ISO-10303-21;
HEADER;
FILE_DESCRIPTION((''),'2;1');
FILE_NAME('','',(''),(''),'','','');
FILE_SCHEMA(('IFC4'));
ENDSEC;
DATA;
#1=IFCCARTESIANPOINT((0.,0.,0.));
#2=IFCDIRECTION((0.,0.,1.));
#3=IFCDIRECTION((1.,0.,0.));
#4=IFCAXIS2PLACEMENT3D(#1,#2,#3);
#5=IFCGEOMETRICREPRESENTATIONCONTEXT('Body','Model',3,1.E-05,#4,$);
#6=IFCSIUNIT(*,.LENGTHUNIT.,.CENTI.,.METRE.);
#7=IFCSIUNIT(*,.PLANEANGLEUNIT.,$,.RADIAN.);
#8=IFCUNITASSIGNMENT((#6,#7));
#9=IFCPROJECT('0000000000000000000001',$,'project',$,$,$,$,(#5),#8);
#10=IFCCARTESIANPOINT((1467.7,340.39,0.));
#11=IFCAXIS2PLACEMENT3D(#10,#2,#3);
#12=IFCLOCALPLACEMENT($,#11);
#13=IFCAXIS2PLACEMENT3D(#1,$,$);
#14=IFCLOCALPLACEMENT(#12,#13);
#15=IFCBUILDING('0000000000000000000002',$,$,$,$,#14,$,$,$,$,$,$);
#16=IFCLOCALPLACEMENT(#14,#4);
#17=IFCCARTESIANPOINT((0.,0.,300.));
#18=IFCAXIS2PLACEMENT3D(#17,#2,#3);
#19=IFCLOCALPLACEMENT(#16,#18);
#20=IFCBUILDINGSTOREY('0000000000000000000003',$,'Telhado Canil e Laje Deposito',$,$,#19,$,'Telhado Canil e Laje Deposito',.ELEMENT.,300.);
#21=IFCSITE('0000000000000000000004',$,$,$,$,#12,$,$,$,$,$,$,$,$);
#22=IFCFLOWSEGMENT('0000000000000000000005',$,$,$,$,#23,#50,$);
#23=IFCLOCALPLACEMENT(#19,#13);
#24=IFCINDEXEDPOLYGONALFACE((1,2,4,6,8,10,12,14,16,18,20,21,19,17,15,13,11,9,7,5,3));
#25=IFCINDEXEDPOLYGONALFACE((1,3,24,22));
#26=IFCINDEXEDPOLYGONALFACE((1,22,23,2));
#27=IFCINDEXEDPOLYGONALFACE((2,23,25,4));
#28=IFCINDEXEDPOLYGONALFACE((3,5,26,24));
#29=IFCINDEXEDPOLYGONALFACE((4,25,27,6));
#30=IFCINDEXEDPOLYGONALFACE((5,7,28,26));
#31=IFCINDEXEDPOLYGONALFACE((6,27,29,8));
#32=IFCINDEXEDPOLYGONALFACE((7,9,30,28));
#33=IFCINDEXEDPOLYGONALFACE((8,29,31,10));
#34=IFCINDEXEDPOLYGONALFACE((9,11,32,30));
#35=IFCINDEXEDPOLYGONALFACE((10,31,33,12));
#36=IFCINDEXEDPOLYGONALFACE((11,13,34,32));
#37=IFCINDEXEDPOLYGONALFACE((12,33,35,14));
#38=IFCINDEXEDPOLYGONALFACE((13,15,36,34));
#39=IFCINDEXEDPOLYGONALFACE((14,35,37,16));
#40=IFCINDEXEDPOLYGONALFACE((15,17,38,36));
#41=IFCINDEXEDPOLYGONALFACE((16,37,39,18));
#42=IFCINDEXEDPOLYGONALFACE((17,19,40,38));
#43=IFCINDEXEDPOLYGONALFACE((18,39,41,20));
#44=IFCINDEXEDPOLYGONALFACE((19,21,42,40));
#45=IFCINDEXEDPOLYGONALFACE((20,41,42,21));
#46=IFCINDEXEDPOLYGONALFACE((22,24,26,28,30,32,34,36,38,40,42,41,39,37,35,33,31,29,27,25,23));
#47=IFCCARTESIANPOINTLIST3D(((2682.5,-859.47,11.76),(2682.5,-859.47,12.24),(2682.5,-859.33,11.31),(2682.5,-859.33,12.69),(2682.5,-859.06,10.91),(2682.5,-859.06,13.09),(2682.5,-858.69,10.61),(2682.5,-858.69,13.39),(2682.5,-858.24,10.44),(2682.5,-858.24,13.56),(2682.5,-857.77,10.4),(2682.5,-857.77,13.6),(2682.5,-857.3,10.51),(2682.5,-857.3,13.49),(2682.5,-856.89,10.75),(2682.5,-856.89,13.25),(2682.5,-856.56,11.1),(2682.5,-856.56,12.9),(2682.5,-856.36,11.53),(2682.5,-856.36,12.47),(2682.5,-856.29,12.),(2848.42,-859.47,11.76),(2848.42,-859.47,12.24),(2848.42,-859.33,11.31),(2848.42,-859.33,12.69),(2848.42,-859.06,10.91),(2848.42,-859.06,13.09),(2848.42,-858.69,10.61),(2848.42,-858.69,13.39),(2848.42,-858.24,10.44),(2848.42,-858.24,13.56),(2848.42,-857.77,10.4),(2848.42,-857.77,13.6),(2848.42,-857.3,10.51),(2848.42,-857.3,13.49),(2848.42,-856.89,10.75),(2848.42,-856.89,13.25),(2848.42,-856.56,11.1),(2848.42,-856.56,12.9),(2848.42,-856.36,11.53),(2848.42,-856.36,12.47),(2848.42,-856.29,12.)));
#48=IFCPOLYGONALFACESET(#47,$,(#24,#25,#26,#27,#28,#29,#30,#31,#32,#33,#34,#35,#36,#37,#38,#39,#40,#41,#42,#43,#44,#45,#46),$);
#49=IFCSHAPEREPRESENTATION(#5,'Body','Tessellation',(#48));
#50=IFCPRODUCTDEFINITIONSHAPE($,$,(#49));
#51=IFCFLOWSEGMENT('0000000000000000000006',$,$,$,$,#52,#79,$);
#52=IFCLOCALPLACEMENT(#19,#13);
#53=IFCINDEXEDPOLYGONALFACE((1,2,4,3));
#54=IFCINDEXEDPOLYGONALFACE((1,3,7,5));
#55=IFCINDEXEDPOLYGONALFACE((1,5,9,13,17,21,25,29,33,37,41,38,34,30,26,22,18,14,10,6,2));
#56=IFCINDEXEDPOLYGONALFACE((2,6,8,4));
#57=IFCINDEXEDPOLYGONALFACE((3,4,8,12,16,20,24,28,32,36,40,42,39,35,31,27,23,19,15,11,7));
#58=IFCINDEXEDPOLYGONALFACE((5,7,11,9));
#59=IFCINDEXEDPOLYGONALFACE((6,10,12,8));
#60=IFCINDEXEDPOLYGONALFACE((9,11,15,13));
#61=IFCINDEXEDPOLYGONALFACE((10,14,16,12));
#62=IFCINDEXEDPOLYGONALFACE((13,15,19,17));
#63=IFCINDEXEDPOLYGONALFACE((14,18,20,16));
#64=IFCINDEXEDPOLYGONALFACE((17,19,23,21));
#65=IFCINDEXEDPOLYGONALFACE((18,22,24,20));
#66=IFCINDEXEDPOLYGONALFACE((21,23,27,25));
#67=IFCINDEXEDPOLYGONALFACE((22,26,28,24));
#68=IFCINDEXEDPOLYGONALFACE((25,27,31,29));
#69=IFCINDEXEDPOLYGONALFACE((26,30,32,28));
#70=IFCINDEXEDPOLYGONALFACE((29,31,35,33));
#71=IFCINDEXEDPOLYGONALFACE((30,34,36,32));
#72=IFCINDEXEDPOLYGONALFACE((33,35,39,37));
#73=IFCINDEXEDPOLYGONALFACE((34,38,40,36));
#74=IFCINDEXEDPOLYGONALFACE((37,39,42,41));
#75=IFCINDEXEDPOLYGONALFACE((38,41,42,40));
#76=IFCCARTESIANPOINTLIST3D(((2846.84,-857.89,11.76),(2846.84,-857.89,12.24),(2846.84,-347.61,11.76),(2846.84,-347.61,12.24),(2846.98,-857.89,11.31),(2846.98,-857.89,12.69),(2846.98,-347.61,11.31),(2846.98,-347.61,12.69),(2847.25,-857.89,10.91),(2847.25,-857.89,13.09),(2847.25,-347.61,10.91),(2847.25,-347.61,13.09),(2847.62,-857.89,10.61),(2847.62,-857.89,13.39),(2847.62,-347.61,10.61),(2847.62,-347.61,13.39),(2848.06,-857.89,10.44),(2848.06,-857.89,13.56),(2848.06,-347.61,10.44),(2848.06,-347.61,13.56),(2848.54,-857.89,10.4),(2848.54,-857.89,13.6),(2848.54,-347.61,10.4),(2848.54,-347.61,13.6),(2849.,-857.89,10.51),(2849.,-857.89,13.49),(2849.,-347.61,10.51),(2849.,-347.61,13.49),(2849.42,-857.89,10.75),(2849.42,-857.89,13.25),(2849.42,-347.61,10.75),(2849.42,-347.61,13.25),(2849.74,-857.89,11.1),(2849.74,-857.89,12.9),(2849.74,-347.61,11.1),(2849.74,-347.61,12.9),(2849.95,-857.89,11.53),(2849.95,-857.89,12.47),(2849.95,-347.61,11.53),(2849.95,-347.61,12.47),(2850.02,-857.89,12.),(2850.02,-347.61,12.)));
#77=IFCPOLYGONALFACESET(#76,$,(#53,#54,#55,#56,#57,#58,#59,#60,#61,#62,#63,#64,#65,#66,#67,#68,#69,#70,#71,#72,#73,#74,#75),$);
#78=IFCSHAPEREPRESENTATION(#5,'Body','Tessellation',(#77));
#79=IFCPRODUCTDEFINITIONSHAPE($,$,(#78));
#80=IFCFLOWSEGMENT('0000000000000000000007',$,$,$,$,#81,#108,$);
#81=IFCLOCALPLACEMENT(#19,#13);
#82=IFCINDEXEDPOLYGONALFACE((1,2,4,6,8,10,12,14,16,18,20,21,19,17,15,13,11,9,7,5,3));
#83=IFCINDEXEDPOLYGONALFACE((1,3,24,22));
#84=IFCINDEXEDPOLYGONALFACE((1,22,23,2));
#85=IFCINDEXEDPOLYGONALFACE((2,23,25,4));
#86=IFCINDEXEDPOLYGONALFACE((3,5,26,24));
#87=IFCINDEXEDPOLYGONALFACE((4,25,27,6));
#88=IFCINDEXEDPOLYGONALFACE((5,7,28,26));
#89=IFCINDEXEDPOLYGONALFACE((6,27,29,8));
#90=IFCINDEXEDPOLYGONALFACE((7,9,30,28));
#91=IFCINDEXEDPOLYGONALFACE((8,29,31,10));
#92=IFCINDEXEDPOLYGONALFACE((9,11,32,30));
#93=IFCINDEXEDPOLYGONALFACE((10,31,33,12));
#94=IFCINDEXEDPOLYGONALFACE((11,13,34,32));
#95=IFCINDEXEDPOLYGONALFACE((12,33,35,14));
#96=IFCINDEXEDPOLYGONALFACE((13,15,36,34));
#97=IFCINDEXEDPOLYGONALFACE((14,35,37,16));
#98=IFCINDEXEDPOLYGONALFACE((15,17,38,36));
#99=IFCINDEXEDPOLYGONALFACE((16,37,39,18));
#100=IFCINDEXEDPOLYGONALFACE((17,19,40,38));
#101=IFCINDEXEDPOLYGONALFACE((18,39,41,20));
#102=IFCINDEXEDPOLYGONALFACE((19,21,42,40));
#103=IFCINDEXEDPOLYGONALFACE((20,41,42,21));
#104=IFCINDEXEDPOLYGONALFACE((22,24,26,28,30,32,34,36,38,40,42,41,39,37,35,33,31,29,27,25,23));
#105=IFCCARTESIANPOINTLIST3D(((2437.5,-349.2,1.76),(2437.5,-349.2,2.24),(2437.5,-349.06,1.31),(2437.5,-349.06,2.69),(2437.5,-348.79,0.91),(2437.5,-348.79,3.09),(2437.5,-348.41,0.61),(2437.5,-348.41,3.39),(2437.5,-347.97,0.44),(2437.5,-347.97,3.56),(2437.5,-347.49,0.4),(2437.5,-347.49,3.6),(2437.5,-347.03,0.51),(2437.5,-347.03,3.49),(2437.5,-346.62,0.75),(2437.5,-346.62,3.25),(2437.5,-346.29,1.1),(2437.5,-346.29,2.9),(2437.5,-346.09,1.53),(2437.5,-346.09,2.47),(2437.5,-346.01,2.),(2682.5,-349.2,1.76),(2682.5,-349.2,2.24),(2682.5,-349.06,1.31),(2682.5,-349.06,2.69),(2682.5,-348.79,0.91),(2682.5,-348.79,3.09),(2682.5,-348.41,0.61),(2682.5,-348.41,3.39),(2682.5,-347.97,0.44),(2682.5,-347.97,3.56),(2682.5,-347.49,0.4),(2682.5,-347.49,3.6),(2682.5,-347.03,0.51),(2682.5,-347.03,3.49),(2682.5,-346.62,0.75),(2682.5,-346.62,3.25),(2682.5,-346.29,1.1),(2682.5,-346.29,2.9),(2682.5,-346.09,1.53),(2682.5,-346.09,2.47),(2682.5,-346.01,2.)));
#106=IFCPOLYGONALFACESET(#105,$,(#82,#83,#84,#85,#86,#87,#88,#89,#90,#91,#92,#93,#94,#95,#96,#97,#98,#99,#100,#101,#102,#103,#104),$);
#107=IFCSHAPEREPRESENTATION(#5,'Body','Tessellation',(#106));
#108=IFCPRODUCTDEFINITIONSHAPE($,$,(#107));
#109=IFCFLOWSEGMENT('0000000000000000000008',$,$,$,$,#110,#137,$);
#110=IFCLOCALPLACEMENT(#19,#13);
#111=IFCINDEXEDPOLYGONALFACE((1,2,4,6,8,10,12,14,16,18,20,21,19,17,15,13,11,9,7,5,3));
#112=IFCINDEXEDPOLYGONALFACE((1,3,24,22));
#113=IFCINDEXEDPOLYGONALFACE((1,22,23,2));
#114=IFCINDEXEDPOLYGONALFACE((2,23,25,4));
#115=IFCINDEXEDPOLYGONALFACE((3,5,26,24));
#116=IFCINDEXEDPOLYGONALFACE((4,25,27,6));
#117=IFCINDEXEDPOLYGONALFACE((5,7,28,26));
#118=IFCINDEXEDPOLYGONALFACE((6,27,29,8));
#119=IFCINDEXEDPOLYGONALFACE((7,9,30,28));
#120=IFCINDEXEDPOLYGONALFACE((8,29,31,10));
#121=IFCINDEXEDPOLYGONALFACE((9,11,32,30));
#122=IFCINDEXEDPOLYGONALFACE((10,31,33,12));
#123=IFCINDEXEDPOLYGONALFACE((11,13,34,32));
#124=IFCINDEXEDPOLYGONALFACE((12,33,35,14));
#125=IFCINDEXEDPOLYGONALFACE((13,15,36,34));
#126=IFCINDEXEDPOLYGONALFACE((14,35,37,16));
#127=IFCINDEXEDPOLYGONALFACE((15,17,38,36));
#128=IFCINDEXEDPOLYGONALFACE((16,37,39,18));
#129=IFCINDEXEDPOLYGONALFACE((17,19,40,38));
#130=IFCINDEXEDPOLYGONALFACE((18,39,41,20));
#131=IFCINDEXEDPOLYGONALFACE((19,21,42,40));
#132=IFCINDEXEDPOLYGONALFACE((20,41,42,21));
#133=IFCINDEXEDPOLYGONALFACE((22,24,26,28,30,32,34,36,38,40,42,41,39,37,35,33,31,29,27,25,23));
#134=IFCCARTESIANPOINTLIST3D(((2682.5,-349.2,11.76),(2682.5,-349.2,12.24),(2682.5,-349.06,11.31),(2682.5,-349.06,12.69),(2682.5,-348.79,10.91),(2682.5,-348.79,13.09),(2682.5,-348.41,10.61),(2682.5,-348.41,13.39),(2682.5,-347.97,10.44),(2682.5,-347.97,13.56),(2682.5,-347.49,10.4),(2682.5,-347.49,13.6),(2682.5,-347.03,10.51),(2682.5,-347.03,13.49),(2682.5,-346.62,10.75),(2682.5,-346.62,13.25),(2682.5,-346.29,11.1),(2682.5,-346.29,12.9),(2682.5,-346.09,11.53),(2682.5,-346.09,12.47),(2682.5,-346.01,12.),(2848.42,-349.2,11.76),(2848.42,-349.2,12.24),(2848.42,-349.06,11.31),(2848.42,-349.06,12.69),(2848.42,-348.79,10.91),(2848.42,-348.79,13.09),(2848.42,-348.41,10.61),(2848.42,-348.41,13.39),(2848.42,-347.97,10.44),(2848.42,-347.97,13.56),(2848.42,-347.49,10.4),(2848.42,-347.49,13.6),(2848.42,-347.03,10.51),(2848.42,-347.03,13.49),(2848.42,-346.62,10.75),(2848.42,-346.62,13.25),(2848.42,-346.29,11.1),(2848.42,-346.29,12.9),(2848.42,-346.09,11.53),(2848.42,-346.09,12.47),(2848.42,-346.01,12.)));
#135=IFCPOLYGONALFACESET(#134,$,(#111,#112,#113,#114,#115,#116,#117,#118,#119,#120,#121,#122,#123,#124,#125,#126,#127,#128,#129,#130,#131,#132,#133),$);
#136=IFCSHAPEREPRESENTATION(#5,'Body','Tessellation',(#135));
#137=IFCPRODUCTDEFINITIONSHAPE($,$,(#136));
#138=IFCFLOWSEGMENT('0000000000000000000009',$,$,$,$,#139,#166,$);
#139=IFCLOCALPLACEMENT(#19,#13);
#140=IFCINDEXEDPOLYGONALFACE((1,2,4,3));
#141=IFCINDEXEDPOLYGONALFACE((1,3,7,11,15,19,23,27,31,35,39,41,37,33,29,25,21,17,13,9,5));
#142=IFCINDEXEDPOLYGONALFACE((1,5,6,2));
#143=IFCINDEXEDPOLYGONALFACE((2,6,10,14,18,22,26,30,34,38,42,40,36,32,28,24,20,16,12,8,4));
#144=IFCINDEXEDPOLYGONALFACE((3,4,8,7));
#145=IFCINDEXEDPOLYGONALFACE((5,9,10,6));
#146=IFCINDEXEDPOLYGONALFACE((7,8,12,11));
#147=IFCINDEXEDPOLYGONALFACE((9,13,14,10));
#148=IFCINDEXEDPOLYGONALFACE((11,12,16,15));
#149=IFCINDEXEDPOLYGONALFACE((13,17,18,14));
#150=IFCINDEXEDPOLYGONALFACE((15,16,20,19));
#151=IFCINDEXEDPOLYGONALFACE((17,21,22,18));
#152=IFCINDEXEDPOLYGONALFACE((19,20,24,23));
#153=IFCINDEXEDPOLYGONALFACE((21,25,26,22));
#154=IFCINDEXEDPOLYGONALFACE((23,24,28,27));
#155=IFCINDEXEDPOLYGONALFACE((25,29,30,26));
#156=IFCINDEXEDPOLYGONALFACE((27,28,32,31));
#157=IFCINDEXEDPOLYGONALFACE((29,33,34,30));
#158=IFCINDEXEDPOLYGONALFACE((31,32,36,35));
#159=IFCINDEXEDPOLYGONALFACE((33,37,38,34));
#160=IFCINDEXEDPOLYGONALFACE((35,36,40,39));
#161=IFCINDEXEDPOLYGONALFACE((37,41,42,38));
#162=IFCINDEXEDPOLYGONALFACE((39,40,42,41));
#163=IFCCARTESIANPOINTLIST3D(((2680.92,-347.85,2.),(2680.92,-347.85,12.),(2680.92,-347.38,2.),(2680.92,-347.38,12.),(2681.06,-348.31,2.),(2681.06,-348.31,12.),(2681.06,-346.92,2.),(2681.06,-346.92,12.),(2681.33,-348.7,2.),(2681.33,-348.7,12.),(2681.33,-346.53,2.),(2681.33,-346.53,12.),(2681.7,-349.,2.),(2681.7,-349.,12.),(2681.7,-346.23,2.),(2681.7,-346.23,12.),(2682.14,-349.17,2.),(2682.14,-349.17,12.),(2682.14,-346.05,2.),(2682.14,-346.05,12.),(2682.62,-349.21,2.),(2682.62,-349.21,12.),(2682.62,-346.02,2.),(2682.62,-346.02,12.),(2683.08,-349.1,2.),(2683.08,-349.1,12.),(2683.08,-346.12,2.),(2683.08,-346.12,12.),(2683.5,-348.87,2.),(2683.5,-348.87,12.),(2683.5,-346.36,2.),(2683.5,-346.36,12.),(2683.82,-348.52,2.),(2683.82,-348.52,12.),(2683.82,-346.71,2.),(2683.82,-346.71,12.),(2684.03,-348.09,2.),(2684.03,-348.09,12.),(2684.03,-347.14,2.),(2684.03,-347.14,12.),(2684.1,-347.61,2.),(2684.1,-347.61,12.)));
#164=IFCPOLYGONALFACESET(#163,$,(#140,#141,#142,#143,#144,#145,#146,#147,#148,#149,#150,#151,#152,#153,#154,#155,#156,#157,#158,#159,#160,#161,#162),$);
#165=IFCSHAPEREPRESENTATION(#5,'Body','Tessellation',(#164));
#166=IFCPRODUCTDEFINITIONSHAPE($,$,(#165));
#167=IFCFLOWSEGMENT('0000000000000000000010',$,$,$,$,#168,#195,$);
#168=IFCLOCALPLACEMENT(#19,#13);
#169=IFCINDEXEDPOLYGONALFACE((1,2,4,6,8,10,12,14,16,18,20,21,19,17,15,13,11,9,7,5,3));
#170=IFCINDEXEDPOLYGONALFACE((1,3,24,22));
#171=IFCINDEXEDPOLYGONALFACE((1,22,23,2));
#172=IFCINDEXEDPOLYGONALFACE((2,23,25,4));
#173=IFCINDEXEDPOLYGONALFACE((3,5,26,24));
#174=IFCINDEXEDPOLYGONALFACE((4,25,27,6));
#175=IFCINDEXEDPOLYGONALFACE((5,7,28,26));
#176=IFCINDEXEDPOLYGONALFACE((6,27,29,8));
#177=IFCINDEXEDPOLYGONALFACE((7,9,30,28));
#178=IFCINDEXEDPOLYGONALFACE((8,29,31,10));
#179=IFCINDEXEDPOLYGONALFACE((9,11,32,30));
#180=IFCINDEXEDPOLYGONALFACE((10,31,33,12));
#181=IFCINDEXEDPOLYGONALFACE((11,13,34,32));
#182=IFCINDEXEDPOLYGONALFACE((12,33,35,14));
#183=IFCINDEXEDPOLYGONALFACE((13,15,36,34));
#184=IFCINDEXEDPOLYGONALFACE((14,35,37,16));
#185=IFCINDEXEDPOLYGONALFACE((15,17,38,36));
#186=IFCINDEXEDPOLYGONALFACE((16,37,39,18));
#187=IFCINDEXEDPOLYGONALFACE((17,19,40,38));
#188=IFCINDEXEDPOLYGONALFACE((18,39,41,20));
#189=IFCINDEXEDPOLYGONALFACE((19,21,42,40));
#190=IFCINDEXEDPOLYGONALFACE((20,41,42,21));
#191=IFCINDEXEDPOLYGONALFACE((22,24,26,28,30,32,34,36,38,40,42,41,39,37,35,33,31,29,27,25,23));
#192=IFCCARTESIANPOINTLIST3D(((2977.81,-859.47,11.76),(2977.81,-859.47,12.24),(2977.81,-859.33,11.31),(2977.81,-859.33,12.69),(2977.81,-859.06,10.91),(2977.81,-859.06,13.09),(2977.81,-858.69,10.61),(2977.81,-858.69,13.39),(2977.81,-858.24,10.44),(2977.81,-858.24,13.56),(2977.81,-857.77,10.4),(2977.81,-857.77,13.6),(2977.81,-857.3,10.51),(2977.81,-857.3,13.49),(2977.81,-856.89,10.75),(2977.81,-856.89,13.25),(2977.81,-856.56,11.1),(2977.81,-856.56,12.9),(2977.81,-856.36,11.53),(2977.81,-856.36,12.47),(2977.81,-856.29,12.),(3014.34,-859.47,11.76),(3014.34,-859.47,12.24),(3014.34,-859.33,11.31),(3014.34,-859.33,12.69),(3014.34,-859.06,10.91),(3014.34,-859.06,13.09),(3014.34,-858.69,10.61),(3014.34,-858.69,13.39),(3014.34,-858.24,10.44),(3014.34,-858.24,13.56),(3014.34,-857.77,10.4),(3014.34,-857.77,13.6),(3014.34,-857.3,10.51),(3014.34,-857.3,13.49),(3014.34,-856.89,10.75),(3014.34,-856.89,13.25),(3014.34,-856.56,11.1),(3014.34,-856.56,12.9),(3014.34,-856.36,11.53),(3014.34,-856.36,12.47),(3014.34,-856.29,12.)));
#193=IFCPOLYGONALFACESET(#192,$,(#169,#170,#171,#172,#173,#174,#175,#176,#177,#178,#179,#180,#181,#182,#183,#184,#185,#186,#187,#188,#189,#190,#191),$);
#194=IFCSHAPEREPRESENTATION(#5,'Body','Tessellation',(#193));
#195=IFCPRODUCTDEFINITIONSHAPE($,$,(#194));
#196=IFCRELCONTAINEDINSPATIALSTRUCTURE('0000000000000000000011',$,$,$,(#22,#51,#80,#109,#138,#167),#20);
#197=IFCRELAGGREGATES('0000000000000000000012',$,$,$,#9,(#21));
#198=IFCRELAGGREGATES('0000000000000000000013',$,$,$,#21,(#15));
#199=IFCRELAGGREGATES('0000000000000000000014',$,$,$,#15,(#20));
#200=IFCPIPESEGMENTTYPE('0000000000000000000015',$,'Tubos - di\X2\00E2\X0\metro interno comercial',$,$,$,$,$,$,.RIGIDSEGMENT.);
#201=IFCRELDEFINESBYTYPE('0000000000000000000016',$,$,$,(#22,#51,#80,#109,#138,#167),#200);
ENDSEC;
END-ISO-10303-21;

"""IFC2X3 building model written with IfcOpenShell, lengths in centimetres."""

from ifc_helpers import new_model, si_unit, frame, origin, origin_with_axes, origin_2d_with_axis, place, context, project, spatial, circle, extrude, type_object, element, save


model = new_model("IFC2X3")

# Units and contexts
model_context = context("Model", 3, precision=1e-05, world=origin_with_axes(), identifier="Body")
ifc_project = project(units=[si_unit("LENGTHUNIT", "METRE", prefix="CENTI"), si_unit("PLANEANGLEUNIT", "RADIAN")], contexts=[model_context])

# Site, building, storey
site_placement = place(None, frame((1467.7, 340.39, 0.0), z_axis=(0.0, 0.0, 1.0), x_axis=(1.0, 0.0, 0.0)))
site = spatial("IfcSite", under=ifc_project, at=site_placement)
building_placement = place(site_placement, origin())
building = spatial("IfcBuilding", under=site, at=building_placement)
placement = place(building_placement, origin_with_axes())
storey_placement = place(placement, frame((0.0, 0.0, 300.0), z_axis=(0.0, 0.0, 1.0), x_axis=(1.0, 0.0, 0.0)))
storey = spatial("IfcBuildingStorey", under=building, at=storey_placement, Name="Telhado Canil e Laje Deposito", LongName="Telhado Canil e Laje Deposito", CompositionType="ELEMENT", Elevation=300.0)

# Flow segments
pipe_segment_type = type_object("IfcPipeSegmentType", Name="Tubos - diâmetro interno comercial", PredefinedType="RIGIDSEGMENT")
flow_segment_1_placement = place(storey_placement, frame((2765.46, -857.89, 13.6), z_axis=(0.0, 0.0, 1.0), x_axis=(1.0, 0.0, 0.0)))
element("IfcFlowSegment", 1, at=flow_segment_1_placement, inside=storey, type_object=pipe_segment_type, context=model_context, shape_type="SolidModel", body=[
    extrude(circle(Radius=1.6, at=origin_2d_with_axis()), frame((82.96, 0.0, -1.6), z_axis=(-1.0, 0.0, 0.0), x_axis=(0.0, 1.0, 0.0)), (0.0, 0.0, 1.0), 165.92),
])
flow_segment_2_placement = place(storey_placement, frame((2848.42, -602.75, 13.6), z_axis=(0.0, 0.0, 1.0), x_axis=(1.0, 0.0, 0.0)))
element("IfcFlowSegment", 2, at=flow_segment_2_placement, inside=storey, type_object=pipe_segment_type, context=model_context, shape_type="SolidModel", body=[
    extrude(circle(Radius=1.6, at=origin_2d_with_axis()), frame((0.0, -255.14, -1.6), z_axis=(0.0, 1.0, 0.0), x_axis=(1.0, 0.0, 0.0)), (0.0, 0.0, 1.0), 510.27),
])
flow_segment_3_placement = place(storey_placement, frame((2560.0, -347.61, 3.6), z_axis=(0.0, 0.0, 1.0), x_axis=(1.0, 0.0, 0.0)))
element("IfcFlowSegment", 3, at=flow_segment_3_placement, inside=storey, type_object=pipe_segment_type, context=model_context, shape_type="SolidModel", body=[
    extrude(circle(Radius=1.6, at=origin_2d_with_axis()), frame((122.5, 0.0, -1.6), z_axis=(-1.0, 0.0, 0.0), x_axis=(0.0, 1.0, 0.0)), (0.0, 0.0, 1.0), 245.0),
])
flow_segment_4_placement = place(storey_placement, frame((2765.46, -347.61, 13.6), z_axis=(0.0, 0.0, 1.0), x_axis=(1.0, 0.0, 0.0)))
element("IfcFlowSegment", 4, at=flow_segment_4_placement, inside=storey, type_object=pipe_segment_type, context=model_context, shape_type="SolidModel", body=[
    extrude(circle(Radius=1.6, at=origin_2d_with_axis()), frame((82.96, 0.0, -1.6), z_axis=(-1.0, 0.0, 0.0), x_axis=(0.0, 1.0, 0.0)), (0.0, 0.0, 1.0), 165.92),
])
flow_segment_5_placement = place(storey_placement, frame((2682.5, -347.61, 12.0), z_axis=(0.0, 0.0, 1.0), x_axis=(1.0, 0.0, 0.0)))
element("IfcFlowSegment", 5, at=flow_segment_5_placement, inside=storey, type_object=pipe_segment_type, context=model_context, shape_type="SolidModel", body=[
    extrude(circle(Radius=1.6, at=origin_2d_with_axis()), frame((0.0, 0.0, 0.0), z_axis=(0.0, 0.0, -1.0), x_axis=(1.0, 0.0, 0.0)), (0.0, 0.0, 1.0), 10.0),
])
flow_segment_6_placement = place(storey_placement, frame((2996.07, -857.89, 13.6), z_axis=(0.0, 0.0, 1.0), x_axis=(1.0, 0.0, 0.0)))
element("IfcFlowSegment", 6, at=flow_segment_6_placement, inside=storey, type_object=pipe_segment_type, context=model_context, shape_type="SolidModel", body=[
    extrude(circle(Radius=1.6, at=origin_2d_with_axis()), frame((18.27, 0.0, -1.6), z_axis=(-1.0, 0.0, 0.0), x_axis=(0.0, 1.0, 0.0)), (0.0, 0.0, 1.0), 36.53),
])

save(model, "model.ifc")
